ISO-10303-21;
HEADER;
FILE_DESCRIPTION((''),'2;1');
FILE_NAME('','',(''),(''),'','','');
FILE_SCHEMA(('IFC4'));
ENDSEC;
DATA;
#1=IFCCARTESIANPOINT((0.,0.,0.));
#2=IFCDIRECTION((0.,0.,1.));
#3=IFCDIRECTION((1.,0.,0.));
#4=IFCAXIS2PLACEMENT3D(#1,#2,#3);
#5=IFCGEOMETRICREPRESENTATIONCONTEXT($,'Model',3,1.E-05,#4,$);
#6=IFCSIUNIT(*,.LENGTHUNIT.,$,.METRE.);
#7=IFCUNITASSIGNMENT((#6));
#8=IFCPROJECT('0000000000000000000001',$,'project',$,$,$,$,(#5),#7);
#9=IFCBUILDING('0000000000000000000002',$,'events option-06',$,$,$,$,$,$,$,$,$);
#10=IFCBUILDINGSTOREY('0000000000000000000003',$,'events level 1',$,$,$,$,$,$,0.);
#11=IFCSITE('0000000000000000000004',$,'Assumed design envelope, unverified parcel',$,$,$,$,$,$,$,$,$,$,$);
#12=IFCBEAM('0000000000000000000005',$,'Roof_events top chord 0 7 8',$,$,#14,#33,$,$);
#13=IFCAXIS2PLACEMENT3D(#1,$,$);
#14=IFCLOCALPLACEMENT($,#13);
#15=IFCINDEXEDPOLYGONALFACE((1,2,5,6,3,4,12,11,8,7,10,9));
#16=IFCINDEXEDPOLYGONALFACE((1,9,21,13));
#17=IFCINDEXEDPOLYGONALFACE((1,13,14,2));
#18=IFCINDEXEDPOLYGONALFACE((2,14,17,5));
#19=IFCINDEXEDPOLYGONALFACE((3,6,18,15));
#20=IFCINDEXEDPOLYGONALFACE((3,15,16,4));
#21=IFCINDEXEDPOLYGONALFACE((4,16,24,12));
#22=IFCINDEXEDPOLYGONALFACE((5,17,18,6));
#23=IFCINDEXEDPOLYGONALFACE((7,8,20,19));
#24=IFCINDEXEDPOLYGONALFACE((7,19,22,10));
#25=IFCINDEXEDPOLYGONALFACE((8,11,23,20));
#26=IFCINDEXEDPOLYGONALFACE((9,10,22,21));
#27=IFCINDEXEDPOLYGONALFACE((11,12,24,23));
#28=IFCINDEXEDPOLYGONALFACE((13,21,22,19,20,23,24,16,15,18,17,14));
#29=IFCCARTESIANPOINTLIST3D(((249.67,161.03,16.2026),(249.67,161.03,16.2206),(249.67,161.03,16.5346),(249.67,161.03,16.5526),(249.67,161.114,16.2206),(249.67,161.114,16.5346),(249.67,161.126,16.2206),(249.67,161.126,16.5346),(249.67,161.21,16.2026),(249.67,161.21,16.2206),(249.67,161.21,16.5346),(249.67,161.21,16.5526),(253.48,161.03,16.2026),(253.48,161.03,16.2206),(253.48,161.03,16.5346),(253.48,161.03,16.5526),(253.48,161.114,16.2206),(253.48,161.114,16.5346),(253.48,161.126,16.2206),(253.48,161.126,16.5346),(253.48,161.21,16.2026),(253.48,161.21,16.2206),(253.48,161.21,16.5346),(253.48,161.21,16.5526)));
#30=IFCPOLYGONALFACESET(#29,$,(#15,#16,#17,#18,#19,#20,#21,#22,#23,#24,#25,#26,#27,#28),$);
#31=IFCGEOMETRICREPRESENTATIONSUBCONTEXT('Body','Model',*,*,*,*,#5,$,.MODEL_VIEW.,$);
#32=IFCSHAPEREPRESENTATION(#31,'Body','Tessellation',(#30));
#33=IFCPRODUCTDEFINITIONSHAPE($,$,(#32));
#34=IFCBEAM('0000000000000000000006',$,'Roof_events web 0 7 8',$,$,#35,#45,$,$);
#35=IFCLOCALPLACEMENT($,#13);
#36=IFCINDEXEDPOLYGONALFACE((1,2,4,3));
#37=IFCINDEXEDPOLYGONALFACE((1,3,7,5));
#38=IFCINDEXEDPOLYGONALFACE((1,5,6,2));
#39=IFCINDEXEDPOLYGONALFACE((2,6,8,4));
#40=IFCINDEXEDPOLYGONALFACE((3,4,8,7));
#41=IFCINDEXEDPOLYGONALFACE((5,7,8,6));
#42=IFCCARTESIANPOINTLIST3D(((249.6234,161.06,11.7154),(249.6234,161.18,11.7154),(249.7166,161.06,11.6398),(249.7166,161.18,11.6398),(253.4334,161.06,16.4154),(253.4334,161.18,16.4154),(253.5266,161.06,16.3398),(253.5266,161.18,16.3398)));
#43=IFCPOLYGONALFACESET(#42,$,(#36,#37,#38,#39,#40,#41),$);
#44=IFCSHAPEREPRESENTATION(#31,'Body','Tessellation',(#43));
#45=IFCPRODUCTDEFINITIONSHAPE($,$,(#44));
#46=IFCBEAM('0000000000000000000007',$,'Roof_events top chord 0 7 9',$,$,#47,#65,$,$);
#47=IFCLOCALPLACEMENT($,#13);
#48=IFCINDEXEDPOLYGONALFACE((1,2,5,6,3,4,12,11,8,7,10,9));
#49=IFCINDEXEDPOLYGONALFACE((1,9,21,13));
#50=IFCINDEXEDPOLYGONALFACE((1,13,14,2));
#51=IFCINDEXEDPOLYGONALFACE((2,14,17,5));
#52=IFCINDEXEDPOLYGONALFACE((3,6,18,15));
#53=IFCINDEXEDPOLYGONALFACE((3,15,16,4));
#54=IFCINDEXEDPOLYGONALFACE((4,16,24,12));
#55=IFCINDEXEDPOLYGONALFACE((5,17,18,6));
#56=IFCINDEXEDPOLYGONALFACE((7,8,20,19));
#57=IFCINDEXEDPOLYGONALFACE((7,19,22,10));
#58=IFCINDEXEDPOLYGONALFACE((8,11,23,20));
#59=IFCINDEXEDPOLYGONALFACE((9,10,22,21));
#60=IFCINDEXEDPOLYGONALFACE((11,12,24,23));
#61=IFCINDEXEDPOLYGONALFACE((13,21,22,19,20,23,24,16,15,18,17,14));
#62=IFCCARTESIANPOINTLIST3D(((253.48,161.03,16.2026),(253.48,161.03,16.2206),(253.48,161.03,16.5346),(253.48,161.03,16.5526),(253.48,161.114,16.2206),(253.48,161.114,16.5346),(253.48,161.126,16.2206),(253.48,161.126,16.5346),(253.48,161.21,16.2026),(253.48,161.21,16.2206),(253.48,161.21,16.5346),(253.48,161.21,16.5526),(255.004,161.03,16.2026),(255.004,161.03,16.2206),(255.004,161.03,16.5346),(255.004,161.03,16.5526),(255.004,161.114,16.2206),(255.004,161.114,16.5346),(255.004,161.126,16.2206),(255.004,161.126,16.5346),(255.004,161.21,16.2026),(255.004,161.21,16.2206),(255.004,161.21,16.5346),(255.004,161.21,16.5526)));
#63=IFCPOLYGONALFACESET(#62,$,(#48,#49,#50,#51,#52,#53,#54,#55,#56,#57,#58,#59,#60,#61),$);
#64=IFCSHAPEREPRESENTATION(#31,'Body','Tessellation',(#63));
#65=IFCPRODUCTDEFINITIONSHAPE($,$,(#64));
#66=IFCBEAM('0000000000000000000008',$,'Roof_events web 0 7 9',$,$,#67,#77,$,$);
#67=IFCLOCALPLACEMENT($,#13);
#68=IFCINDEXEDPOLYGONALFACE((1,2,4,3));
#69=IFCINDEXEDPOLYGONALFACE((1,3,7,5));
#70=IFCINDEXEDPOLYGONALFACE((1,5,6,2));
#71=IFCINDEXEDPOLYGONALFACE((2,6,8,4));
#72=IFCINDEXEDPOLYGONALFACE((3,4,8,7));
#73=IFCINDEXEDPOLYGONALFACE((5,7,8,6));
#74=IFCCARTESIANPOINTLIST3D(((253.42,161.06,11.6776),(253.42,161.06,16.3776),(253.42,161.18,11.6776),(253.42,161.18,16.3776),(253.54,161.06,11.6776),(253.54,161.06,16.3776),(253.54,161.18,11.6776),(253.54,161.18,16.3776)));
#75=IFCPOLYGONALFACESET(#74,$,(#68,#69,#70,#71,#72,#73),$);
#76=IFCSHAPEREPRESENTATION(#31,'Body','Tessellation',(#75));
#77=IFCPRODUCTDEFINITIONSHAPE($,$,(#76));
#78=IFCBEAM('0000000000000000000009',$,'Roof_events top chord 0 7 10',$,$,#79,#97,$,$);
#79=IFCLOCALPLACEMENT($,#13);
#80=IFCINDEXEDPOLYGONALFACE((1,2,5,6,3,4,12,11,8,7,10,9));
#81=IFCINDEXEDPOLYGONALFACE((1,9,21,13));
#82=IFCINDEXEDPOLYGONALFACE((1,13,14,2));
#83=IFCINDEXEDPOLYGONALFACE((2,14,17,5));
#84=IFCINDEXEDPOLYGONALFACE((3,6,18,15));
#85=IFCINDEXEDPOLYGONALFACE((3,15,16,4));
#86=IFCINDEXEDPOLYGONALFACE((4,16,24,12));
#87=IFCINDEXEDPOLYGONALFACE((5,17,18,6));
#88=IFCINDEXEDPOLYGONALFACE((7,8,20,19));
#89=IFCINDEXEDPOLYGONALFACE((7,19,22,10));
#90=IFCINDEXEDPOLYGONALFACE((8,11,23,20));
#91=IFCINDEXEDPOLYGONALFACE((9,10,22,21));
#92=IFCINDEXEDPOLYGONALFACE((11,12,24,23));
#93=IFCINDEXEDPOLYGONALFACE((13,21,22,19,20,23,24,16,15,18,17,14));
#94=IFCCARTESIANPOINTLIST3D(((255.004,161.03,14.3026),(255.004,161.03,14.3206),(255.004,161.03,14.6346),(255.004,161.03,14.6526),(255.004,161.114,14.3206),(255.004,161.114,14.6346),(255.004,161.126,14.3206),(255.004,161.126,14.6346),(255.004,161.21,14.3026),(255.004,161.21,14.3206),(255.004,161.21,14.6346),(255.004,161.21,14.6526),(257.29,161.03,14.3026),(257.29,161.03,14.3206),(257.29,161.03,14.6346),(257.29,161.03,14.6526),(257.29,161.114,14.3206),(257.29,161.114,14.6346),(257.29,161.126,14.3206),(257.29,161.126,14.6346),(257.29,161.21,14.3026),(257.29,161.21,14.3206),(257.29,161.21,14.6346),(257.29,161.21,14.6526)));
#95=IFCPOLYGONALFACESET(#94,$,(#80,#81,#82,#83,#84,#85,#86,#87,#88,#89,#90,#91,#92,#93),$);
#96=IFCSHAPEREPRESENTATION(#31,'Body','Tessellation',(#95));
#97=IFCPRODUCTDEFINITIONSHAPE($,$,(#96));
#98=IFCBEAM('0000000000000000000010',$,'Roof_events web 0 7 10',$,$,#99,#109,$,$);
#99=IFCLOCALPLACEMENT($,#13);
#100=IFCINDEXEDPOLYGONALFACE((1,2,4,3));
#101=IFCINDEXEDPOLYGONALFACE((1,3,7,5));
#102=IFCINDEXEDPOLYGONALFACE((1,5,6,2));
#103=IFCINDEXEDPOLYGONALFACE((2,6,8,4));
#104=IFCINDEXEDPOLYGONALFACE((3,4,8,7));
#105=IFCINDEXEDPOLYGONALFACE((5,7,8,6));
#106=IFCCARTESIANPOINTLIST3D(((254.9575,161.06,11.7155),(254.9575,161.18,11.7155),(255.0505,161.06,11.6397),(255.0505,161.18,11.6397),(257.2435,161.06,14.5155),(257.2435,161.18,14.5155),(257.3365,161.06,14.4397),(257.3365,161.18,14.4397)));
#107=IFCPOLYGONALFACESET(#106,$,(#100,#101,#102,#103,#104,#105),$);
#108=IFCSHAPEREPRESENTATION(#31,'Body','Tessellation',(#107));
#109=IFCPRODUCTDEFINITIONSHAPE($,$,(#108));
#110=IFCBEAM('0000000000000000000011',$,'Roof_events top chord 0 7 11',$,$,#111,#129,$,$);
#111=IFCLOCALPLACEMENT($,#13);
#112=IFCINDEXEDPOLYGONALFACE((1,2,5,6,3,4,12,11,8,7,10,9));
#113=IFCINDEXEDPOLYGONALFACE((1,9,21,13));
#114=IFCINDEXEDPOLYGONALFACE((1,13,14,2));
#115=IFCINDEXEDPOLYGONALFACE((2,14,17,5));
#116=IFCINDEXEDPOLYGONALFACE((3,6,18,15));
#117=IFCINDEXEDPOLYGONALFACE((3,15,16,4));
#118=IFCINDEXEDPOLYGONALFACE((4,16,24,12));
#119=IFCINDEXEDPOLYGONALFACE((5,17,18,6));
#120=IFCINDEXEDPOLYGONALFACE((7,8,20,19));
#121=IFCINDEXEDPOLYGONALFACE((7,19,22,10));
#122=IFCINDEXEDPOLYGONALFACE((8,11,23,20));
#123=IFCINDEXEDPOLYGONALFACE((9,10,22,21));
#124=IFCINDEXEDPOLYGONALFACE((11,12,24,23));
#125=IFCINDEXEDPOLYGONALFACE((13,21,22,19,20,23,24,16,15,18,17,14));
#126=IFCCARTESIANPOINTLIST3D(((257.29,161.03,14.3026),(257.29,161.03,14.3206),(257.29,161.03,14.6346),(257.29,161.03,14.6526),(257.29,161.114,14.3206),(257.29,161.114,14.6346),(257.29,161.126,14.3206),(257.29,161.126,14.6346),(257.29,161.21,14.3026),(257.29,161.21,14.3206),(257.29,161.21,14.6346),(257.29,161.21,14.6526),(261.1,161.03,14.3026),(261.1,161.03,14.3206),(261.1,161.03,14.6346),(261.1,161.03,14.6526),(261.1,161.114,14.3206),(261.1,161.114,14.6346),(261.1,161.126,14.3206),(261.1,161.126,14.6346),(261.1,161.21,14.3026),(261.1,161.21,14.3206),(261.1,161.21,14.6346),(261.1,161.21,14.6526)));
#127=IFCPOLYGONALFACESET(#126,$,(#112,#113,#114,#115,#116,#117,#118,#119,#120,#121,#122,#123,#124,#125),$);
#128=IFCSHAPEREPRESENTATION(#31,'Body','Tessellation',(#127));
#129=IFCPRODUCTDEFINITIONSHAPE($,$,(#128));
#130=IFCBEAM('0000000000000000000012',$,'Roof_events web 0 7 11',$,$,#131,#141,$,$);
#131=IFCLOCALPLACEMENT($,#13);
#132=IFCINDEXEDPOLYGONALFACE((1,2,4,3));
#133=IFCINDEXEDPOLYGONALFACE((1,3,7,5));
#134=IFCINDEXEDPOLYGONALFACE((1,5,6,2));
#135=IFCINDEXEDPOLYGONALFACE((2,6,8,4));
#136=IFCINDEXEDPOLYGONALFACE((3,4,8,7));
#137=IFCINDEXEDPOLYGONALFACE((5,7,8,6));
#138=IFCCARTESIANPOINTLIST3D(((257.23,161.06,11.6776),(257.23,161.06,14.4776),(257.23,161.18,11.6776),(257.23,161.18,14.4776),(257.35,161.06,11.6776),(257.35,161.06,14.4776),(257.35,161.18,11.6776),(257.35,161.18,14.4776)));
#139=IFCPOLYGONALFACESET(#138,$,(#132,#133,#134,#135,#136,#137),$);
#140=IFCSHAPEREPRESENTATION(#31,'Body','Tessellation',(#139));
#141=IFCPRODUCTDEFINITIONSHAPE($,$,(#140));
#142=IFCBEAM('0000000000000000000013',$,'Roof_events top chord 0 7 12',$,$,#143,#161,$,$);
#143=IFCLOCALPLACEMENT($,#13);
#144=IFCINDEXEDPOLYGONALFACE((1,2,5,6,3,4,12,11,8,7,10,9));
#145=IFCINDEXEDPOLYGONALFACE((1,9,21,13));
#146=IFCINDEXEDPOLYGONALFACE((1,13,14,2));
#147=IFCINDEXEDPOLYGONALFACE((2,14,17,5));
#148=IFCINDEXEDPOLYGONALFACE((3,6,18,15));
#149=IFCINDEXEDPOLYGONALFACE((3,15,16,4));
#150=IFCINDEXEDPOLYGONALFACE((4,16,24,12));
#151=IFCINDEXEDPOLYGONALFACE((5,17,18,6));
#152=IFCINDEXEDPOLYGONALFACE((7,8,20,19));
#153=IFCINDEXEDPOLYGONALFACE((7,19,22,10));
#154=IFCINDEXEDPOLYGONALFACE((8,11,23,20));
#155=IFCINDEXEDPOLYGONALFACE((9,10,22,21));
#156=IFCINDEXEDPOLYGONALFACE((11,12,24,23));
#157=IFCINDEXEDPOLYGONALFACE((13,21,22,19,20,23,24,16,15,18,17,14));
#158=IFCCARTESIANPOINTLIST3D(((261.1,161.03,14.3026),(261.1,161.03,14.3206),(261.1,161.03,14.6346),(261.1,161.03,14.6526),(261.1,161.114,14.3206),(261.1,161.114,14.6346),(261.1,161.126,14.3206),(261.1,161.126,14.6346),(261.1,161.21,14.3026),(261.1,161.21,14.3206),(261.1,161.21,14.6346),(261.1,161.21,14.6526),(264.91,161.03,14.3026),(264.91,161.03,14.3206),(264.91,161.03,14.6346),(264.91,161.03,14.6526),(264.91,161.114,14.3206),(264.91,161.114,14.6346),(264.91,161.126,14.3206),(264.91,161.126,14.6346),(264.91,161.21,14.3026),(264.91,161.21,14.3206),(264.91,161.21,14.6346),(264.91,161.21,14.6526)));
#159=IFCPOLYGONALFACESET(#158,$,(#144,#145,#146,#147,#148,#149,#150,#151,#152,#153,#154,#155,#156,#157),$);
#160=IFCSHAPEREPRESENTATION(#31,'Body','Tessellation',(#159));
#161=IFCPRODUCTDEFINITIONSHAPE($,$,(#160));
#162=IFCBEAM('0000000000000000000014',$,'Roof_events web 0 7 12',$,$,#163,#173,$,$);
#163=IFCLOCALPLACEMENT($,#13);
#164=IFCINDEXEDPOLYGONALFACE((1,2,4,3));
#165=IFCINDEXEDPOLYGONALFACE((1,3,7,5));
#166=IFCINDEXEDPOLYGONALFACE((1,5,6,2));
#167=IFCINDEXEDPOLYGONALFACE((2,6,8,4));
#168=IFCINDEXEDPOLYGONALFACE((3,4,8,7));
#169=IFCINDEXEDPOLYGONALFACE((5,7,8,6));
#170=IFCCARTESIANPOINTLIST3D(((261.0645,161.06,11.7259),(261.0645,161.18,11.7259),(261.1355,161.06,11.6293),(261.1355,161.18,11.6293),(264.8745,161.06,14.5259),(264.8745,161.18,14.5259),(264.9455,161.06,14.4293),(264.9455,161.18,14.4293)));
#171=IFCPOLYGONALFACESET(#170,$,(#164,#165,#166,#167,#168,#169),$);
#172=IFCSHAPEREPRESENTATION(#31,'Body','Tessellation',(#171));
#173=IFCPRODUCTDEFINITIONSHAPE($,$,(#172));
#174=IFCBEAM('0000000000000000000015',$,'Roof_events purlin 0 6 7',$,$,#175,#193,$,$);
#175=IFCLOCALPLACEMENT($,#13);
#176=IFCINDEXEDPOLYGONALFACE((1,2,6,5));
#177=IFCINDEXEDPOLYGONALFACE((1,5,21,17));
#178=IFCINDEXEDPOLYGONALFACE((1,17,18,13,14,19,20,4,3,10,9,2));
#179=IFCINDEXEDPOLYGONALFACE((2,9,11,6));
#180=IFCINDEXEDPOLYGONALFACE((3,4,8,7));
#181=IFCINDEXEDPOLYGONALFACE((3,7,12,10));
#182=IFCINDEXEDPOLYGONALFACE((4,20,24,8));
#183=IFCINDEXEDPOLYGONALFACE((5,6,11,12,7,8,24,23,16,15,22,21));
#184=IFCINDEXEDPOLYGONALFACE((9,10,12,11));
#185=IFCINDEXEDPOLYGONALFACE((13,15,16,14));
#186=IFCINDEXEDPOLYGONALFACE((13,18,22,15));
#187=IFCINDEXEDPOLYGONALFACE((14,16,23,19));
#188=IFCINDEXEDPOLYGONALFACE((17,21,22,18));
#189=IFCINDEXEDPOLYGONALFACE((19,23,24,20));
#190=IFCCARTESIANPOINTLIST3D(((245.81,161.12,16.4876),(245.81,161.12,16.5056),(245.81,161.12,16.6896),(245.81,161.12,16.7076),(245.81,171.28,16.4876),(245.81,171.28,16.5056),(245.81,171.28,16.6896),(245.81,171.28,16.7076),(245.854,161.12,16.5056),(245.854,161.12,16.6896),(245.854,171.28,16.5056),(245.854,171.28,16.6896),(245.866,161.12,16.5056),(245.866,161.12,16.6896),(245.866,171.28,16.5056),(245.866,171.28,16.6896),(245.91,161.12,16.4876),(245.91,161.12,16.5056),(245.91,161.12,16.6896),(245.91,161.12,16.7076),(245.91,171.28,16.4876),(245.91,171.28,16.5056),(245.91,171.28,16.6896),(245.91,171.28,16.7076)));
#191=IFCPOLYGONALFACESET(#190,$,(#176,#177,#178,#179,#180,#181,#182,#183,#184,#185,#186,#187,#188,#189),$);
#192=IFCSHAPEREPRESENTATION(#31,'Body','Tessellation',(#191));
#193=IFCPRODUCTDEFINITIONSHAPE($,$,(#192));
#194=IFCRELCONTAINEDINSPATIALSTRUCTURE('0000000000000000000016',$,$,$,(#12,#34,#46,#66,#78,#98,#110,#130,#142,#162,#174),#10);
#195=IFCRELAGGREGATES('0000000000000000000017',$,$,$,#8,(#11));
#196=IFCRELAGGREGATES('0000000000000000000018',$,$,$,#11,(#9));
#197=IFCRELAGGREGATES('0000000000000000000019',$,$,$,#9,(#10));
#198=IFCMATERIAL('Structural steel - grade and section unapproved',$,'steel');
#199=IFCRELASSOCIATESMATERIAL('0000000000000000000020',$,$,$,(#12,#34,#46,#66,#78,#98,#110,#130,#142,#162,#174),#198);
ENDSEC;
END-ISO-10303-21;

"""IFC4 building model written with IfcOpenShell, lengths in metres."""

from ifc_helpers import new_model, si_unit, frame, origin_with_axes, place, context, subcontext, project, spatial, rectangle, i_section, extrude, material, element, save


model = new_model("IFC4")

# Units and contexts
model_context = context("Model", 3, precision=1e-05, world=origin_with_axes())
body_context = subcontext(model_context, "Body", "Model", "MODEL_VIEW")
ifc_project = project(units=[si_unit("LENGTHUNIT", "METRE")], contexts=[model_context])

# Site, building, storey
site = spatial("IfcSite", under=ifc_project, Name="Assumed design envelope, unverified parcel")
building = spatial("IfcBuilding", under=site, Name="events option-06")
storey = spatial("IfcBuildingStorey", under=building, Name="events level 1", Elevation=0.0)

# Beams
ifc_material = material(Name="Structural steel - grade and section unapproved", Category="steel")
beam_1_placement = place(None, frame((249.67, 161.12, 16.3776), z_axis=(1.0, 0.0, 0.0), x_axis=(0.0, 1.0, 0.0)))
element("IfcBeam", 1, at=beam_1_placement, inside=storey, material=ifc_material, Name="Roof_events top chord 0 7 8", context=body_context, shape_type="SweptSolid", body=[
    extrude(i_section(OverallWidth=0.18, OverallDepth=0.35, WebThickness=0.012, FlangeThickness=0.018, FilletRadius=0.0), origin_with_axes(), (0.0, 0.0, 1.0), 3.81),
])
beam_2_placement = place(None, frame((249.67, 161.12, 11.6776), z_axis=(0.629721, 0.0, 0.776821), x_axis=(0.0, 1.0, 0.0)))
element("IfcBeam", 2, at=beam_2_placement, inside=storey, material=ifc_material, Name="Roof_events web 0 7 8", context=body_context, shape_type="SweptSolid", body=[
    extrude(rectangle(XDim=0.12, YDim=0.12), origin_with_axes(), (0.0, 0.0, 1.0), 6.0503),
])
beam_3_placement = place(None, frame((253.48, 161.12, 16.3776), z_axis=(1.0, 0.0, 0.0), x_axis=(0.0, 1.0, 0.0)))
element("IfcBeam", 3, at=beam_3_placement, inside=storey, material=ifc_material, Name="Roof_events top chord 0 7 9", context=body_context, shape_type="SweptSolid", body=[
    extrude(i_section(OverallWidth=0.18, OverallDepth=0.35, WebThickness=0.012, FlangeThickness=0.018, FilletRadius=0.0), origin_with_axes(), (0.0, 0.0, 1.0), 1.524),
])
beam_4_placement = place(None, frame((253.48, 161.12, 11.6776), z_axis=(0.0, 0.0, 1.0), x_axis=(-1.0, 0.0, 0.0)))
element("IfcBeam", 4, at=beam_4_placement, inside=storey, material=ifc_material, Name="Roof_events web 0 7 9", context=body_context, shape_type="SweptSolid", body=[
    extrude(rectangle(XDim=0.12, YDim=0.12), origin_with_axes(), (0.0, 0.0, 1.0), 4.7),
])
beam_5_placement = place(None, frame((255.004, 161.12, 14.4776), z_axis=(1.0, 0.0, 0.0), x_axis=(0.0, 1.0, 0.0)))
element("IfcBeam", 5, at=beam_5_placement, inside=storey, material=ifc_material, Name="Roof_events top chord 0 7 10", context=body_context, shape_type="SweptSolid", body=[
    extrude(i_section(OverallWidth=0.18, OverallDepth=0.35, WebThickness=0.012, FlangeThickness=0.018, FilletRadius=0.0), origin_with_axes(), (0.0, 0.0, 1.0), 2.286),
])
beam_6_placement = place(None, frame((255.004, 161.12, 11.6776), z_axis=(0.632426, 0.0, 0.774621), x_axis=(0.0, 1.0, 0.0)))
element("IfcBeam", 6, at=beam_6_placement, inside=storey, material=ifc_material, Name="Roof_events web 0 7 10", context=body_context, shape_type="SweptSolid", body=[
    extrude(rectangle(XDim=0.12, YDim=0.12), origin_with_axes(), (0.0, 0.0, 1.0), 3.6147),
])
beam_7_placement = place(None, frame((257.29, 161.12, 14.4776), z_axis=(1.0, 0.0, 0.0), x_axis=(0.0, 1.0, 0.0)))
element("IfcBeam", 7, at=beam_7_placement, inside=storey, material=ifc_material, Name="Roof_events top chord 0 7 11", context=body_context, shape_type="SweptSolid", body=[
    extrude(i_section(OverallWidth=0.18, OverallDepth=0.35, WebThickness=0.012, FlangeThickness=0.018, FilletRadius=0.0), origin_with_axes(), (0.0, 0.0, 1.0), 3.81),
])
beam_8_placement = place(None, frame((257.29, 161.12, 11.6776), z_axis=(0.0, 0.0, 1.0), x_axis=(-1.0, 0.0, 0.0)))
element("IfcBeam", 8, at=beam_8_placement, inside=storey, material=ifc_material, Name="Roof_events web 0 7 11", context=body_context, shape_type="SweptSolid", body=[
    extrude(rectangle(XDim=0.12, YDim=0.12), origin_with_axes(), (0.0, 0.0, 1.0), 2.8),
])
beam_9_placement = place(None, frame((261.1, 161.12, 14.4776), z_axis=(1.0, 0.0, 0.0), x_axis=(0.0, 1.0, 0.0)))
element("IfcBeam", 9, at=beam_9_placement, inside=storey, material=ifc_material, Name="Roof_events top chord 0 7 12", context=body_context, shape_type="SweptSolid", body=[
    extrude(i_section(OverallWidth=0.18, OverallDepth=0.35, WebThickness=0.012, FlangeThickness=0.018, FilletRadius=0.0), origin_with_axes(), (0.0, 0.0, 1.0), 3.81),
])
beam_10_placement = place(None, frame((261.1, 161.12, 11.6776), z_axis=(0.805799, 0.0, 0.592189), x_axis=(0.0, 1.0, 0.0)))
element("IfcBeam", 10, at=beam_10_placement, inside=storey, material=ifc_material, Name="Roof_events web 0 7 12", context=body_context, shape_type="SweptSolid", body=[
    extrude(rectangle(XDim=0.12, YDim=0.12), origin_with_axes(), (0.0, 0.0, 1.0), 4.7282),
])
beam_11_placement = place(None, frame((245.86, 161.12, 16.5976), z_axis=(0.0, 1.0, 0.0), x_axis=(-1.0, 0.0, 0.0)))
element("IfcBeam", 11, at=beam_11_placement, inside=storey, material=ifc_material, Name="Roof_events purlin 0 6 7", context=body_context, shape_type="SweptSolid", body=[
    extrude(i_section(OverallWidth=0.1, OverallDepth=0.22, WebThickness=0.012, FlangeThickness=0.018, FilletRadius=0.0), origin_with_axes(), (0.0, 0.0, 1.0), 10.16),
])

save(model, "model.ifc")
